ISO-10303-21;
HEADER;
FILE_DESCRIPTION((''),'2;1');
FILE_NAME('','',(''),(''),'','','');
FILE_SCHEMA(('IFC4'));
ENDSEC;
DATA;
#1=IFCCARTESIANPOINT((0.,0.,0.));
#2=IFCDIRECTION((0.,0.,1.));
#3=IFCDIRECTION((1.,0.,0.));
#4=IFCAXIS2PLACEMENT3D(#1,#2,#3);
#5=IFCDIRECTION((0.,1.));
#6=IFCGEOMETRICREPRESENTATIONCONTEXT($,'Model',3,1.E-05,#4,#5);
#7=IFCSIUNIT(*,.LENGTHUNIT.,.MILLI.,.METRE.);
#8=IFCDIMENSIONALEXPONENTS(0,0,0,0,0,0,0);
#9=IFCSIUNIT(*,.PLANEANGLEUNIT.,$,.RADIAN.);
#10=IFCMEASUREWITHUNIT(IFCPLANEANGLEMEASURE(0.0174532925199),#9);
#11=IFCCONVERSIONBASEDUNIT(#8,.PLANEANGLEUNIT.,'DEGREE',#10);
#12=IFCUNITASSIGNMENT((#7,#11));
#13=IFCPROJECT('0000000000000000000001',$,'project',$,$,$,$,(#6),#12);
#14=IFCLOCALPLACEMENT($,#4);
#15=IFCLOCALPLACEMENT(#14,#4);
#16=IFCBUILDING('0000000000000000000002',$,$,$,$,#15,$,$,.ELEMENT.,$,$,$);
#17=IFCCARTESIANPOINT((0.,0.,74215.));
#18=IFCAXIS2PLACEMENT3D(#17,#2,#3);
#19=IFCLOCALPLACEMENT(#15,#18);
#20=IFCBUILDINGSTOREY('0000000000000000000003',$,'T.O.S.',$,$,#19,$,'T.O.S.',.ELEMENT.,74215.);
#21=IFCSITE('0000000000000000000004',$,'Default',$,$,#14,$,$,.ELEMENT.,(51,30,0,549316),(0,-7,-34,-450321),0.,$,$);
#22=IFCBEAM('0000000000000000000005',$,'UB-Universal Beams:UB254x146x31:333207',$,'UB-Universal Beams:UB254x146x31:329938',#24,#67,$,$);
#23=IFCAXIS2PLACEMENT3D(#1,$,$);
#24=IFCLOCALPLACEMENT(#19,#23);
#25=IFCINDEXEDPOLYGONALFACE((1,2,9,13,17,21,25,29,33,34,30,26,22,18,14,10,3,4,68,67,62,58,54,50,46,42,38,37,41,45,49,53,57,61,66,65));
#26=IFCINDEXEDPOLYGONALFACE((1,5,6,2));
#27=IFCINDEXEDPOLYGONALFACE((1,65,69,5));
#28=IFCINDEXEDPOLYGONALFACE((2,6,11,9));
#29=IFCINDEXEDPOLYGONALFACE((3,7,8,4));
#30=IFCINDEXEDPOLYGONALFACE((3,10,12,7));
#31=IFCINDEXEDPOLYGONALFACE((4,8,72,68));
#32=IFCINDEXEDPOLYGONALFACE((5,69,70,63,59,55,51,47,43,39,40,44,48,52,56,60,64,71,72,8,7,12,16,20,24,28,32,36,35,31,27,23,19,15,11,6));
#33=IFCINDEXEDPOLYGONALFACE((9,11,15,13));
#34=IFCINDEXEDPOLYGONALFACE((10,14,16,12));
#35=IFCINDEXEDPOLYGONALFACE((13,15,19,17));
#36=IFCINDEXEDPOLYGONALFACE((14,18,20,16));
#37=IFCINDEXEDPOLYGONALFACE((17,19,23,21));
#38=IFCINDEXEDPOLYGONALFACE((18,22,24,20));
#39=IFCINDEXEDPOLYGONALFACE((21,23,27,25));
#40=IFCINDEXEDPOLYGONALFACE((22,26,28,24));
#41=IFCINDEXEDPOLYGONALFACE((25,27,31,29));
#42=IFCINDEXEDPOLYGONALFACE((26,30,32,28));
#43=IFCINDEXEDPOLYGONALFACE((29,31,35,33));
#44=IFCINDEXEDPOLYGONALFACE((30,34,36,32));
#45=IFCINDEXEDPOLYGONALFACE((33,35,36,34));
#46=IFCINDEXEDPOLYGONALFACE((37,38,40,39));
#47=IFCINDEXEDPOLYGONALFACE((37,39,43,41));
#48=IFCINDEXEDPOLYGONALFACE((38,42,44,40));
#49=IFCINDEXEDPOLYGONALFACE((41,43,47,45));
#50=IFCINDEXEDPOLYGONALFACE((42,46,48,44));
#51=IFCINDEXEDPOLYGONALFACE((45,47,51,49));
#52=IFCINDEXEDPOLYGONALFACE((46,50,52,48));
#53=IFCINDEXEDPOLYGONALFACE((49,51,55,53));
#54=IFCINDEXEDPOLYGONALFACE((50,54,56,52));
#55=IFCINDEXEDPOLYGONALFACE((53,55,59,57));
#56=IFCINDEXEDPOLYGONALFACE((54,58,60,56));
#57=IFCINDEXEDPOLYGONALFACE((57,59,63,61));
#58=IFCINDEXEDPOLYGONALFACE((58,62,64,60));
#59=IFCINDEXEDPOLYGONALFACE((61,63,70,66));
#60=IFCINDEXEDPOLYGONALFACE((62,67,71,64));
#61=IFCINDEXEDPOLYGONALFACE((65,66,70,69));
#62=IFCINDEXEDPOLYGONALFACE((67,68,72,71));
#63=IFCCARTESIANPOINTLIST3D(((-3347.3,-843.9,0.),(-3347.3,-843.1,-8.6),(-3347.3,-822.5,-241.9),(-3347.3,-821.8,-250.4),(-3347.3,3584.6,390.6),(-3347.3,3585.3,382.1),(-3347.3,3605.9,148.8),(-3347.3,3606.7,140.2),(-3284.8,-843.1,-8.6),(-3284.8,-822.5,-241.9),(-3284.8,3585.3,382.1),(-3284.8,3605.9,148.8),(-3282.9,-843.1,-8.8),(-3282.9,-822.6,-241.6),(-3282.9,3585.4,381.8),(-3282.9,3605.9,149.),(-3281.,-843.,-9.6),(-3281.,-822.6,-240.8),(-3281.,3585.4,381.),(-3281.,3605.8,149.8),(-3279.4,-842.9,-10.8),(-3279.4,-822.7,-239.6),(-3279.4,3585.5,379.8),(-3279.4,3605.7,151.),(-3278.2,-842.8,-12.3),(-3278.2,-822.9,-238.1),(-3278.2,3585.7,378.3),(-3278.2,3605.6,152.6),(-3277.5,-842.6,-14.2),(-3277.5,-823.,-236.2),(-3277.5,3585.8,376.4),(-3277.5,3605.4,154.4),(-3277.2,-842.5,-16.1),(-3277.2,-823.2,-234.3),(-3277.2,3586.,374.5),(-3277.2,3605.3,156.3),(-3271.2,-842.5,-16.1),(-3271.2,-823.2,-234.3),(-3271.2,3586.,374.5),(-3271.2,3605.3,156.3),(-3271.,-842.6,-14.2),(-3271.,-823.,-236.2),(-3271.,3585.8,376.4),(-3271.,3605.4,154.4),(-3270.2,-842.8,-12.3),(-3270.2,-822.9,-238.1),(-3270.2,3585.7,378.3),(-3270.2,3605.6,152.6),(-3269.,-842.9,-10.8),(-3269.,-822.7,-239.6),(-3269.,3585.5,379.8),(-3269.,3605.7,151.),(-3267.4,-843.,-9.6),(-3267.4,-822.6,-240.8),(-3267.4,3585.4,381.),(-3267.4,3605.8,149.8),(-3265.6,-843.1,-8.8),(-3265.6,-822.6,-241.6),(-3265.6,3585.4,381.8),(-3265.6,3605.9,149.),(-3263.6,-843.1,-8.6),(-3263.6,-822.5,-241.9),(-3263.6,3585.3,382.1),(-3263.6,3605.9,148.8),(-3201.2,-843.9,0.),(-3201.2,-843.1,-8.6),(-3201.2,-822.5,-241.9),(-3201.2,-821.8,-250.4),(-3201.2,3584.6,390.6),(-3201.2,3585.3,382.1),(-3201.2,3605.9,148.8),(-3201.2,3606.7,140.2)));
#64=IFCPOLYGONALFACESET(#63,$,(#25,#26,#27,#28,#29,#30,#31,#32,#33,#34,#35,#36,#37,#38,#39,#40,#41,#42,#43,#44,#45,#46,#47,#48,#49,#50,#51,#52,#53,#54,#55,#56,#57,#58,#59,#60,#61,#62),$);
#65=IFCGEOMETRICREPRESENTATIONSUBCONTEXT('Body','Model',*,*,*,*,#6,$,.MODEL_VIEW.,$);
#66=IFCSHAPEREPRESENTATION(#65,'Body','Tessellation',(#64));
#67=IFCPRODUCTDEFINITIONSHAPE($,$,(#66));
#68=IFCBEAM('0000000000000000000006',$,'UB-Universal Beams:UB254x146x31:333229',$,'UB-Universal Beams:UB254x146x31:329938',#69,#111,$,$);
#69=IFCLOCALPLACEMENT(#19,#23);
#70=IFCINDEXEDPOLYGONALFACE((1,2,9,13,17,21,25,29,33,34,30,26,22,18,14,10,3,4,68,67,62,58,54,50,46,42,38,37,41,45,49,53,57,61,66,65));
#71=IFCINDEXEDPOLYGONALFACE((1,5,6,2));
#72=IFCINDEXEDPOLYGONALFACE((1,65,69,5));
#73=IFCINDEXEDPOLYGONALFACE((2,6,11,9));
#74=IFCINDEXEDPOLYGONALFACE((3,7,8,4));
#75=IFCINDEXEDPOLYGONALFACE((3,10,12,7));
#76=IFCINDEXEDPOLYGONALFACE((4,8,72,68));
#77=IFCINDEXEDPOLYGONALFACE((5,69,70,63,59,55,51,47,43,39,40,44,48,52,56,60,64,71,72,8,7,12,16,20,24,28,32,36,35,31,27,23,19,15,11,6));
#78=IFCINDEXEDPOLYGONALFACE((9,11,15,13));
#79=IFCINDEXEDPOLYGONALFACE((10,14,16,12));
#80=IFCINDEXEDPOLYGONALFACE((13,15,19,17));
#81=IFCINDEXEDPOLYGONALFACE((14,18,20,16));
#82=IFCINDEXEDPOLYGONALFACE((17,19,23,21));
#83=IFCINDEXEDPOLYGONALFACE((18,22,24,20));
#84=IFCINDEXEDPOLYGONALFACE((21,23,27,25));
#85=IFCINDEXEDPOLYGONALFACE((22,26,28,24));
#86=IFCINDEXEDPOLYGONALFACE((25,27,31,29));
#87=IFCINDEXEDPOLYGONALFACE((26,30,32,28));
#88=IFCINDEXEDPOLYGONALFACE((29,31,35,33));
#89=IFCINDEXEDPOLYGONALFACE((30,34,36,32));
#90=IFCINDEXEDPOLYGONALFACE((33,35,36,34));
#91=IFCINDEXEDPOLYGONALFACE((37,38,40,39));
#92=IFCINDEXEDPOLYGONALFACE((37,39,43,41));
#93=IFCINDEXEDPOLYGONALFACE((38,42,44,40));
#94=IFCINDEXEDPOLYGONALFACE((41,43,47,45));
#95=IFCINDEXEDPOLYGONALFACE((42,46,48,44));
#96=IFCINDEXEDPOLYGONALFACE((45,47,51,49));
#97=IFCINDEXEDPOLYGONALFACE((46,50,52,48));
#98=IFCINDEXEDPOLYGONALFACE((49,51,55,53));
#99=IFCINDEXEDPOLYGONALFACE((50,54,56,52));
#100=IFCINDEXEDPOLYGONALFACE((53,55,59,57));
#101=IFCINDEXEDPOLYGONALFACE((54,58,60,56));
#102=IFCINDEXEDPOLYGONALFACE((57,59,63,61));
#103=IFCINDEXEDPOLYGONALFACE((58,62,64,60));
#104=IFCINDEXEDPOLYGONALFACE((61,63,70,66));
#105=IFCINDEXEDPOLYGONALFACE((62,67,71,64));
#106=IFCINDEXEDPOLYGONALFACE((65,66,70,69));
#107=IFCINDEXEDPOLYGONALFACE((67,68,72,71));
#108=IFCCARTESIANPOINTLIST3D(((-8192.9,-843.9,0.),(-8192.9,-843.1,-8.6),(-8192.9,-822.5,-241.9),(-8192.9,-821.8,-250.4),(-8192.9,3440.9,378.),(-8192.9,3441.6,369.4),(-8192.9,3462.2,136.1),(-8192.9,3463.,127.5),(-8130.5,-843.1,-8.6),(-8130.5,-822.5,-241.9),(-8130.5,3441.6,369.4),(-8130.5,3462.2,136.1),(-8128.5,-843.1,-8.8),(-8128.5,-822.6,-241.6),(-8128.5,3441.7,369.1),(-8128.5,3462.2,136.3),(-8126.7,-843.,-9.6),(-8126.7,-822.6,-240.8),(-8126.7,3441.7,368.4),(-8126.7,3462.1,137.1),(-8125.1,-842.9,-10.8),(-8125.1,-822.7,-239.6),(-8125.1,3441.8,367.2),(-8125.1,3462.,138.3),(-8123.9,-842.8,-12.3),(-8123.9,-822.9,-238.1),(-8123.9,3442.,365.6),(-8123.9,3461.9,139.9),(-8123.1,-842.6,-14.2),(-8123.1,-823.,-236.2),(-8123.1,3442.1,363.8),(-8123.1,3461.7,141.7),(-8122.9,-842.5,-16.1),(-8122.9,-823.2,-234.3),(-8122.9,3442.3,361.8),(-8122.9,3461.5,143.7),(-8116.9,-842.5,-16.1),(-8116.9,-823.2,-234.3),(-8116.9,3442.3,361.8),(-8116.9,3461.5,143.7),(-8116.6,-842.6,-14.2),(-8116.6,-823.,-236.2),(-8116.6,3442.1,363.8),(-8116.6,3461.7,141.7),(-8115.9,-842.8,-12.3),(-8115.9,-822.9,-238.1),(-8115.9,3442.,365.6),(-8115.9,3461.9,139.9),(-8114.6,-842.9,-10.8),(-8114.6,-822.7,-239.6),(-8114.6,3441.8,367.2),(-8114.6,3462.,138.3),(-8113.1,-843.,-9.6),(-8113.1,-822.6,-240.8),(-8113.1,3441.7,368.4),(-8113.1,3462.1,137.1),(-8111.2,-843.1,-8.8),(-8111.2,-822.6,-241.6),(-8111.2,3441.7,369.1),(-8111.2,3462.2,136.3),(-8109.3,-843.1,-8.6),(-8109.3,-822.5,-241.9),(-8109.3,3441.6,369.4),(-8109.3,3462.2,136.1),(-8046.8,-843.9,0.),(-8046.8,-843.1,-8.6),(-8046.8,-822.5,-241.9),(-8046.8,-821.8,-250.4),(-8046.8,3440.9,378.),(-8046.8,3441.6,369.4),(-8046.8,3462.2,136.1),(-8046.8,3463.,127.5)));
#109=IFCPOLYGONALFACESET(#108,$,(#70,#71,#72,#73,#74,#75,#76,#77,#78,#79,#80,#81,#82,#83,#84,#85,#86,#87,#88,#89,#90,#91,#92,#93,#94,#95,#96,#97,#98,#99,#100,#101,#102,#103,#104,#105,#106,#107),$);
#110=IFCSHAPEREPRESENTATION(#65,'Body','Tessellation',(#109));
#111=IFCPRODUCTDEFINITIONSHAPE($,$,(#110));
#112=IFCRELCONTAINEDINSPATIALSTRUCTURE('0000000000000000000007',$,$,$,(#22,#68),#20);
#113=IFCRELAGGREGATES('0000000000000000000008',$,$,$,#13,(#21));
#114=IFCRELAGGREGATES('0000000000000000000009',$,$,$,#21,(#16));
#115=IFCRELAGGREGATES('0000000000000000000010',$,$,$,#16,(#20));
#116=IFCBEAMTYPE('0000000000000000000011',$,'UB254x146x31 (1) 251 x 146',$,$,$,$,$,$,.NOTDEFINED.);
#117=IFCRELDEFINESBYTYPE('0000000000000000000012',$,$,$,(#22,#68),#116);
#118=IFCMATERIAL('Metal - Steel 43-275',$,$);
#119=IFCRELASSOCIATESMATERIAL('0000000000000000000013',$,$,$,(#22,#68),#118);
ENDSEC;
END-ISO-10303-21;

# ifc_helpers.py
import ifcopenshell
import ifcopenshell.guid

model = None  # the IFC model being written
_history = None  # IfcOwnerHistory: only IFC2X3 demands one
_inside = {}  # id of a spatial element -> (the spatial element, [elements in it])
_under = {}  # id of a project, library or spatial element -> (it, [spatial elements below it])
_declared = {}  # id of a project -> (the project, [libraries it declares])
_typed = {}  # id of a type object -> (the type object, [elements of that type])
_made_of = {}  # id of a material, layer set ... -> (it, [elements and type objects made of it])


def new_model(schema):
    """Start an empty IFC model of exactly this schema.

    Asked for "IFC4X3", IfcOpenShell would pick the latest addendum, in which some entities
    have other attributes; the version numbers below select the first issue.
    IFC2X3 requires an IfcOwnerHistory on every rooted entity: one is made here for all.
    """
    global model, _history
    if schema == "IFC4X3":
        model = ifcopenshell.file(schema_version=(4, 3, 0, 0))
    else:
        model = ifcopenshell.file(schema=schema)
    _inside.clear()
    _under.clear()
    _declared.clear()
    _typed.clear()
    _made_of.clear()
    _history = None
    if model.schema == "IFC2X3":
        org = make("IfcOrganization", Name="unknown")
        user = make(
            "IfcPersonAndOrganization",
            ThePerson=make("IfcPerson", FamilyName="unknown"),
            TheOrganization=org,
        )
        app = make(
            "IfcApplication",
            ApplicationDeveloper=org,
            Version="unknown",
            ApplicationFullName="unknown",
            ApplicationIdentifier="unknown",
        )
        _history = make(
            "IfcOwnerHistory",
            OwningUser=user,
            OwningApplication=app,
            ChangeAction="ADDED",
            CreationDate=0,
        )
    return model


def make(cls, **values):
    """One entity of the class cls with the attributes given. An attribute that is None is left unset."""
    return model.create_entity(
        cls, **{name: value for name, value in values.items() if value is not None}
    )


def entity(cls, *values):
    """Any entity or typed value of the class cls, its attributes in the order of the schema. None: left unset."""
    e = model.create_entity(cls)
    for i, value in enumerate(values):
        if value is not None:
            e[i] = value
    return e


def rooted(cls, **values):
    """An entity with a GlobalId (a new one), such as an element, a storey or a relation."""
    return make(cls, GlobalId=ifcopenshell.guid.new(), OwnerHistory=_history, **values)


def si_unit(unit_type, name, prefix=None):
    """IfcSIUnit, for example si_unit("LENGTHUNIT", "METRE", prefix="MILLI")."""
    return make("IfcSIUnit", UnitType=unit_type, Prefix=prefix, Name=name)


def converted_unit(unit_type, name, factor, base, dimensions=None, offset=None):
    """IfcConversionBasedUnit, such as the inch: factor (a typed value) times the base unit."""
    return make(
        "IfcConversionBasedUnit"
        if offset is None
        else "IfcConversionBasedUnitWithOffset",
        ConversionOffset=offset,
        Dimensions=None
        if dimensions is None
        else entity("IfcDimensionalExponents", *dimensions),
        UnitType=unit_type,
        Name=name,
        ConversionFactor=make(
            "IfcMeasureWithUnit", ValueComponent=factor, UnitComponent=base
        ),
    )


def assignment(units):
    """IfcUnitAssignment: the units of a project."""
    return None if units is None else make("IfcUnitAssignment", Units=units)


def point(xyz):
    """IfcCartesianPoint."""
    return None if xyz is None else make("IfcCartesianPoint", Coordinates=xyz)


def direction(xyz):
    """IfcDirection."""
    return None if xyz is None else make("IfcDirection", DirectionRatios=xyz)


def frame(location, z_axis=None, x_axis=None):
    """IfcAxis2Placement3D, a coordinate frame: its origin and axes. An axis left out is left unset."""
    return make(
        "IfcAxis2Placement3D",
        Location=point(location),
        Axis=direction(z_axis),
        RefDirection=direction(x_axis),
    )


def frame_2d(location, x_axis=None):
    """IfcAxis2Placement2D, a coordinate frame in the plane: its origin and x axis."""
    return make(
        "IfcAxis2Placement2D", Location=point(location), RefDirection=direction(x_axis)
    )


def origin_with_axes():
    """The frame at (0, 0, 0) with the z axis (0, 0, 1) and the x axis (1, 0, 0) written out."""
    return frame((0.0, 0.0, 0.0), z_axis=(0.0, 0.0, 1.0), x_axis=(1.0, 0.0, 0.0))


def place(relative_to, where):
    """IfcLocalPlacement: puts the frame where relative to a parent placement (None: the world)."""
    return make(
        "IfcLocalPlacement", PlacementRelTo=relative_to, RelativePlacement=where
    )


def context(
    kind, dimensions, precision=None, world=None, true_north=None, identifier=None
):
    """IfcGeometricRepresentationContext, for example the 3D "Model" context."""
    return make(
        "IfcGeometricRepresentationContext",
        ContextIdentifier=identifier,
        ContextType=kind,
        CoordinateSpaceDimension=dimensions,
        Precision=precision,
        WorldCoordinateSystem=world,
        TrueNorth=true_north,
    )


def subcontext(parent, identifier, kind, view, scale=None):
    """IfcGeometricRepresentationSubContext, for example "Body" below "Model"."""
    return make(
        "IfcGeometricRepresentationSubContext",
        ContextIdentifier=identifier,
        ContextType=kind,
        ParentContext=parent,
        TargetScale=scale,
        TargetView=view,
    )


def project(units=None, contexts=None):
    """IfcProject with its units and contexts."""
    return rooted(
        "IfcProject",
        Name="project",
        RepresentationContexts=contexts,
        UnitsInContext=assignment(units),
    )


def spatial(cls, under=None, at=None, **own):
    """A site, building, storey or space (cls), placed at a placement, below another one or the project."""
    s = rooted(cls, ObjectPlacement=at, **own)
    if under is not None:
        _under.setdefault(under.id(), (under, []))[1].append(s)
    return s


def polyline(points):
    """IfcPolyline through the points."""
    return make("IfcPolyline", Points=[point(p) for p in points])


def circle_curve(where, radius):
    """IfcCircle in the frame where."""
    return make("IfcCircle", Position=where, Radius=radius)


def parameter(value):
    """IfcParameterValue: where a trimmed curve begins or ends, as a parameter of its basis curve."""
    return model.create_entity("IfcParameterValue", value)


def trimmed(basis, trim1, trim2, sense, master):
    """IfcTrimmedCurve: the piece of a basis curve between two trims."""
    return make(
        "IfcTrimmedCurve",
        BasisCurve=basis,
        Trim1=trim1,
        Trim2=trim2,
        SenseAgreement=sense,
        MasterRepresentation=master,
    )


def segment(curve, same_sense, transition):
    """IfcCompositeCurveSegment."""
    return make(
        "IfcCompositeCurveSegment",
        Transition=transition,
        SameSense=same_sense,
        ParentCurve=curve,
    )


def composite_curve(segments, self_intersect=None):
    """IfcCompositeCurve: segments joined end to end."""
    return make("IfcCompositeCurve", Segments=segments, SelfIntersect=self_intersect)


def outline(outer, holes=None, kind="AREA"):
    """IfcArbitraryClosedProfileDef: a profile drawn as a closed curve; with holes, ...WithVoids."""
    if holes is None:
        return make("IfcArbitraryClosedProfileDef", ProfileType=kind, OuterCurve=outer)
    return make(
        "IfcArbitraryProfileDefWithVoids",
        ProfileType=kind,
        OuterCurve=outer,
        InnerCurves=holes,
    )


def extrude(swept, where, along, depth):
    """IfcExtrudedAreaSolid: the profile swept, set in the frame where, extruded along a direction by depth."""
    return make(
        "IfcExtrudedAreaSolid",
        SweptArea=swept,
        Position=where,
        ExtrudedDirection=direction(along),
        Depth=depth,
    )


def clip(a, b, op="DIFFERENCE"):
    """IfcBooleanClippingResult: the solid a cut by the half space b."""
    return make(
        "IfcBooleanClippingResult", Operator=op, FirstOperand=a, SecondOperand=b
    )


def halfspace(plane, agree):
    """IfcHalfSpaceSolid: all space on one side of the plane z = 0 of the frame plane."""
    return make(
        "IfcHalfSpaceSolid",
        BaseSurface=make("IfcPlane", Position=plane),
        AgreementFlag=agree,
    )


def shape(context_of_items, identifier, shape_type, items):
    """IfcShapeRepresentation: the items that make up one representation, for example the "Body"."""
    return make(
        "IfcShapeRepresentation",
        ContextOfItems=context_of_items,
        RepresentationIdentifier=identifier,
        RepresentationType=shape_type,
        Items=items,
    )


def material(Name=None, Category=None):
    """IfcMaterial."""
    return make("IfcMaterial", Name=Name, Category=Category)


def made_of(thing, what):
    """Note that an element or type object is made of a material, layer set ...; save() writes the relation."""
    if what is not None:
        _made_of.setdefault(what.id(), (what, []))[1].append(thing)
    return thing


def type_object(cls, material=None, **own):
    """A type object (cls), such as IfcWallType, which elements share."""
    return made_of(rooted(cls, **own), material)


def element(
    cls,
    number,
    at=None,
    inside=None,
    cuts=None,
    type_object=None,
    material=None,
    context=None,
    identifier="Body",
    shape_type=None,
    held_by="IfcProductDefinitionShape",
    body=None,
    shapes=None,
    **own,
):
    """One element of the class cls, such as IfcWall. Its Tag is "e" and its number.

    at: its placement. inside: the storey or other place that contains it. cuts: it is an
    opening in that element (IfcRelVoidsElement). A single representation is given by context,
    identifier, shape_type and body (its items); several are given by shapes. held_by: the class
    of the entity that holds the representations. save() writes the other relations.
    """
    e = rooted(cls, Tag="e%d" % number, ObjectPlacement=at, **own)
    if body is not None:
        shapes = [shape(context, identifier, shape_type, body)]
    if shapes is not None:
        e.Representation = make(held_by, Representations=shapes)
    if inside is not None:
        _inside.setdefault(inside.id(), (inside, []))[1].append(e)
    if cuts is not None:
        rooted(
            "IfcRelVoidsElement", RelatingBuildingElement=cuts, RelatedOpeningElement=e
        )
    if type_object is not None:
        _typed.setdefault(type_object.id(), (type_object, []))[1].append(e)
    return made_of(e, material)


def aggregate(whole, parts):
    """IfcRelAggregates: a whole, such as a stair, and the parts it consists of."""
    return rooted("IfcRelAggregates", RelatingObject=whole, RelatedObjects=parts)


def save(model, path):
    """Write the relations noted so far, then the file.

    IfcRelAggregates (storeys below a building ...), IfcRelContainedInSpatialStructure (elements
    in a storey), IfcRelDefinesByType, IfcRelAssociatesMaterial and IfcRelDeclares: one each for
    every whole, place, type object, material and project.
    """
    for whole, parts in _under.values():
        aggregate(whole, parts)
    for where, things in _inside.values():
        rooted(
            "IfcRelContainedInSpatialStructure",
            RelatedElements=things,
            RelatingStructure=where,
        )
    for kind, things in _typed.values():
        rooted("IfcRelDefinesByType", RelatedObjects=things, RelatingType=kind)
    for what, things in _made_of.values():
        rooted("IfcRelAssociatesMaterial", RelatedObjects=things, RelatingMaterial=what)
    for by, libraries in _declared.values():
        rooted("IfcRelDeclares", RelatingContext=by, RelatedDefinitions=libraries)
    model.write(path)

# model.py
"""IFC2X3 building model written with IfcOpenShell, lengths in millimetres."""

from ifc_helpers import new_model, entity, si_unit, converted_unit, point, direction, frame, frame_2d, origin_with_axes, place, context, subcontext, project, spatial, polyline, circle_curve, parameter, trimmed, segment, composite_curve, outline, extrude, clip, halfspace, material, type_object, element, save


model = new_model("IFC2X3")

# Units and contexts
model_context = context("Model", 3, precision=1e-05, world=origin_with_axes(), true_north=direction((0.0, 1.0)))
body_context = subcontext(model_context, "Body", "Model", "MODEL_VIEW")
ifc_project = project(units=[si_unit("LENGTHUNIT", "METRE", prefix="MILLI"), converted_unit("PLANEANGLEUNIT", "DEGREE", entity("IfcPlaneAngleMeasure", 0.0174532925199), si_unit("PLANEANGLEUNIT", "RADIAN"), dimensions=[0, 0, 0, 0, 0, 0, 0])], contexts=[model_context])

# Site, building, storey
site_placement = place(None, origin_with_axes())
site = spatial("IfcSite", under=ifc_project, at=site_placement, Name="Default", CompositionType="ELEMENT", RefLatitude=(51, 30, 0, 549316), RefLongitude=(0, -7, -34, -450321), RefElevation=0.0)
building_placement = place(site_placement, origin_with_axes())
building = spatial("IfcBuilding", under=site, at=building_placement, CompositionType="ELEMENT")
storey_placement = place(building_placement, frame((0.0, 0.0, 74215.0), z_axis=(0.0, 0.0, 1.0), x_axis=(1.0, 0.0, 0.0)))
storey = spatial("IfcBuildingStorey", under=building, at=storey_placement, Name="T.O.S.", LongName="T.O.S.", CompositionType="ELEMENT", Elevation=74215.0)

# Beams
ifc_material = material(Name="Metal - Steel 43-275")
beam_type_1 = type_object("IfcBeamType", Name="UB254x146x31 (1) 251 x 146", PredefinedType="NOTDEFINED")
beam_1_placement = place(storey_placement, frame((-3274.2, 3613.8, 267.0), z_axis=(0.0, 0.0, 1.0), x_axis=(-1.0, 0.0, 0.0)))
element("IfcBeam", 1, at=beam_1_placement, inside=storey, type_object=beam_type_1, material=ifc_material, Name="UB-Universal Beams:UB254x146x31:333207", ObjectType="UB-Universal Beams:UB254x146x31:329938", context=body_context, shape_type="Clipping", body=[
    clip(clip(clip(clip(extrude(outline(composite_curve([segment(polyline([(125.7, 73.0), (117.1, 73.0), (117.1, 10.6)]), True, "CONTINUOUS"), segment(trimmed(circle_curve(frame_2d((109.5, 10.6), x_axis=(0.0, -1.0)), 7.6), [point((117.1, 10.6)), parameter(90.0)], [point((109.5, 3.0)), parameter(0.0)], False, "CARTESIAN"), True, "CONTINUOUS"), segment(polyline([(109.5, 3.0), (-109.5, 3.0)]), True, "CONTINUOUS"), segment(trimmed(circle_curve(frame_2d((-109.5, 10.6), x_axis=(-1.0, 0.0)), 7.6), [point((-109.5, 3.0)), parameter(90.0)], [point((-117.1, 10.6)), parameter(0.0)], False, "CARTESIAN"), True, "CONTINUOUS"), segment(polyline([(-117.1, 10.6), (-117.1, 73.0), (-125.7, 73.0), (-125.7, -73.0), (-117.1, -73.0), (-117.1, -10.6)]), True, "CONTINUOUS"), segment(trimmed(circle_curve(frame_2d((-109.5, -10.6), x_axis=(0.0, 1.0)), 7.6), [point((-117.1, -10.6)), parameter(90.0)], [point((-109.5, -3.0)), parameter(0.0)], False, "CARTESIAN"), True, "CONTINUOUS"), segment(polyline([(-109.5, -3.0), (109.5, -3.0)]), True, "CONTINUOUS"), segment(trimmed(circle_curve(frame_2d((109.5, -10.6), x_axis=(1.0, 0.0)), 7.6), [point((109.5, -3.0)), parameter(90.0)], [point((117.1, -10.6)), parameter(0.0)], False, "CARTESIAN"), True, "CONTINUOUS"), segment(polyline([(117.1, -10.6), (117.1, -73.0), (125.7, -73.0), (125.7, 73.0)]), True, "CONTINUOUS")], self_intersect=False)), frame((0.0, 4482.9, -395.4), z_axis=(0.0, -0.996132, 0.087866), x_axis=(0.0, -0.087866, -0.996132)), (0.0, 0.0, 1.0), 4518.6), halfspace(frame((0.0, 4446.6, -392.2), z_axis=(0.0, -0.996132, 0.087866), x_axis=(0.0, -0.087866, -0.996132)), True)), halfspace(frame((0.0, 18.2, -1.6), z_axis=(0.0, 0.996132, -0.087866), x_axis=(0.0, 0.087866, 0.996132)), True)), halfspace(frame((0.0, 4464.8, 0.0), z_axis=(0.0, -1.0, 0.0), x_axis=(0.0, 0.0, -1.0)), True)), halfspace(frame((0.0, 0.0, 0.0), z_axis=(0.0, 1.0, 0.0), x_axis=(0.0, 0.0, 1.0)), True)),
])
beam_2_placement = place(storey_placement, frame((-8119.9, 3470.1, 254.3), z_axis=(0.0, 0.0, 1.0), x_axis=(-1.0, 0.0, 0.0)))
element("IfcBeam", 2, at=beam_2_placement, inside=storey, type_object=beam_type_1, material=ifc_material, Name="UB-Universal Beams:UB254x146x31:333229", ObjectType="UB-Universal Beams:UB254x146x31:329938", context=body_context, shape_type="Clipping", body=[
    clip(clip(clip(clip(extrude(outline(composite_curve([segment(polyline([(125.7, 73.0), (117.1, 73.0), (117.1, 10.6)]), True, "CONTINUOUS"), segment(trimmed(circle_curve(frame_2d((109.5, 10.6), x_axis=(0.0, -1.0)), 7.6), [point((117.1, 10.6)), parameter(90.0)], [point((109.5, 3.0)), parameter(0.0)], False, "CARTESIAN"), True, "CONTINUOUS"), segment(polyline([(109.5, 3.0), (-109.5, 3.0)]), True, "CONTINUOUS"), segment(trimmed(circle_curve(frame_2d((-109.5, 10.6), x_axis=(-1.0, 0.0)), 7.6), [point((-109.5, 3.0)), parameter(90.0)], [point((-117.1, 10.6)), parameter(0.0)], False, "CARTESIAN"), True, "CONTINUOUS"), segment(polyline([(-117.1, 10.6), (-117.1, 73.0), (-125.7, 73.0), (-125.7, -73.0), (-117.1, -73.0), (-117.1, -10.6)]), True, "CONTINUOUS"), segment(trimmed(circle_curve(frame_2d((-109.5, -10.6), x_axis=(0.0, 1.0)), 7.6), [point((-117.1, -10.6)), parameter(90.0)], [point((-109.5, -3.0)), parameter(0.0)], False, "CARTESIAN"), True, "CONTINUOUS"), segment(polyline([(-109.5, -3.0), (109.5, -3.0)]), True, "CONTINUOUS"), segment(trimmed(circle_curve(frame_2d((109.5, -10.6), x_axis=(1.0, 0.0)), 7.6), [point((109.5, -3.0)), parameter(90.0)], [point((117.1, -10.6)), parameter(0.0)], False, "CARTESIAN"), True, "CONTINUOUS"), segment(polyline([(117.1, -10.6), (117.1, -73.0), (125.7, -73.0), (125.7, 73.0)]), True, "CONTINUOUS")], self_intersect=False)), frame((0.0, 4339.2, -382.8), z_axis=(0.0, -0.996132, 0.087866), x_axis=(0.0, -0.087866, -0.996132)), (0.0, 0.0, 1.0), 4374.3), halfspace(frame((0.0, 4302.9, -379.5), z_axis=(0.0, -0.996132, 0.087866), x_axis=(0.0, -0.087866, -0.996132)), True)), halfspace(frame((0.0, 18.2, -1.6), z_axis=(0.0, 0.996132, -0.087866), x_axis=(0.0, 0.087866, 0.996132)), True)), halfspace(frame((0.0, 4321.1, 0.0), z_axis=(0.0, -1.0, 0.0), x_axis=(0.0, 0.0, -1.0)), True)), halfspace(frame((0.0, 0.0, 0.0), z_axis=(0.0, 1.0, 0.0), x_axis=(0.0, 0.0, 1.0)), True)),
])

save(model, "model.ifc")
